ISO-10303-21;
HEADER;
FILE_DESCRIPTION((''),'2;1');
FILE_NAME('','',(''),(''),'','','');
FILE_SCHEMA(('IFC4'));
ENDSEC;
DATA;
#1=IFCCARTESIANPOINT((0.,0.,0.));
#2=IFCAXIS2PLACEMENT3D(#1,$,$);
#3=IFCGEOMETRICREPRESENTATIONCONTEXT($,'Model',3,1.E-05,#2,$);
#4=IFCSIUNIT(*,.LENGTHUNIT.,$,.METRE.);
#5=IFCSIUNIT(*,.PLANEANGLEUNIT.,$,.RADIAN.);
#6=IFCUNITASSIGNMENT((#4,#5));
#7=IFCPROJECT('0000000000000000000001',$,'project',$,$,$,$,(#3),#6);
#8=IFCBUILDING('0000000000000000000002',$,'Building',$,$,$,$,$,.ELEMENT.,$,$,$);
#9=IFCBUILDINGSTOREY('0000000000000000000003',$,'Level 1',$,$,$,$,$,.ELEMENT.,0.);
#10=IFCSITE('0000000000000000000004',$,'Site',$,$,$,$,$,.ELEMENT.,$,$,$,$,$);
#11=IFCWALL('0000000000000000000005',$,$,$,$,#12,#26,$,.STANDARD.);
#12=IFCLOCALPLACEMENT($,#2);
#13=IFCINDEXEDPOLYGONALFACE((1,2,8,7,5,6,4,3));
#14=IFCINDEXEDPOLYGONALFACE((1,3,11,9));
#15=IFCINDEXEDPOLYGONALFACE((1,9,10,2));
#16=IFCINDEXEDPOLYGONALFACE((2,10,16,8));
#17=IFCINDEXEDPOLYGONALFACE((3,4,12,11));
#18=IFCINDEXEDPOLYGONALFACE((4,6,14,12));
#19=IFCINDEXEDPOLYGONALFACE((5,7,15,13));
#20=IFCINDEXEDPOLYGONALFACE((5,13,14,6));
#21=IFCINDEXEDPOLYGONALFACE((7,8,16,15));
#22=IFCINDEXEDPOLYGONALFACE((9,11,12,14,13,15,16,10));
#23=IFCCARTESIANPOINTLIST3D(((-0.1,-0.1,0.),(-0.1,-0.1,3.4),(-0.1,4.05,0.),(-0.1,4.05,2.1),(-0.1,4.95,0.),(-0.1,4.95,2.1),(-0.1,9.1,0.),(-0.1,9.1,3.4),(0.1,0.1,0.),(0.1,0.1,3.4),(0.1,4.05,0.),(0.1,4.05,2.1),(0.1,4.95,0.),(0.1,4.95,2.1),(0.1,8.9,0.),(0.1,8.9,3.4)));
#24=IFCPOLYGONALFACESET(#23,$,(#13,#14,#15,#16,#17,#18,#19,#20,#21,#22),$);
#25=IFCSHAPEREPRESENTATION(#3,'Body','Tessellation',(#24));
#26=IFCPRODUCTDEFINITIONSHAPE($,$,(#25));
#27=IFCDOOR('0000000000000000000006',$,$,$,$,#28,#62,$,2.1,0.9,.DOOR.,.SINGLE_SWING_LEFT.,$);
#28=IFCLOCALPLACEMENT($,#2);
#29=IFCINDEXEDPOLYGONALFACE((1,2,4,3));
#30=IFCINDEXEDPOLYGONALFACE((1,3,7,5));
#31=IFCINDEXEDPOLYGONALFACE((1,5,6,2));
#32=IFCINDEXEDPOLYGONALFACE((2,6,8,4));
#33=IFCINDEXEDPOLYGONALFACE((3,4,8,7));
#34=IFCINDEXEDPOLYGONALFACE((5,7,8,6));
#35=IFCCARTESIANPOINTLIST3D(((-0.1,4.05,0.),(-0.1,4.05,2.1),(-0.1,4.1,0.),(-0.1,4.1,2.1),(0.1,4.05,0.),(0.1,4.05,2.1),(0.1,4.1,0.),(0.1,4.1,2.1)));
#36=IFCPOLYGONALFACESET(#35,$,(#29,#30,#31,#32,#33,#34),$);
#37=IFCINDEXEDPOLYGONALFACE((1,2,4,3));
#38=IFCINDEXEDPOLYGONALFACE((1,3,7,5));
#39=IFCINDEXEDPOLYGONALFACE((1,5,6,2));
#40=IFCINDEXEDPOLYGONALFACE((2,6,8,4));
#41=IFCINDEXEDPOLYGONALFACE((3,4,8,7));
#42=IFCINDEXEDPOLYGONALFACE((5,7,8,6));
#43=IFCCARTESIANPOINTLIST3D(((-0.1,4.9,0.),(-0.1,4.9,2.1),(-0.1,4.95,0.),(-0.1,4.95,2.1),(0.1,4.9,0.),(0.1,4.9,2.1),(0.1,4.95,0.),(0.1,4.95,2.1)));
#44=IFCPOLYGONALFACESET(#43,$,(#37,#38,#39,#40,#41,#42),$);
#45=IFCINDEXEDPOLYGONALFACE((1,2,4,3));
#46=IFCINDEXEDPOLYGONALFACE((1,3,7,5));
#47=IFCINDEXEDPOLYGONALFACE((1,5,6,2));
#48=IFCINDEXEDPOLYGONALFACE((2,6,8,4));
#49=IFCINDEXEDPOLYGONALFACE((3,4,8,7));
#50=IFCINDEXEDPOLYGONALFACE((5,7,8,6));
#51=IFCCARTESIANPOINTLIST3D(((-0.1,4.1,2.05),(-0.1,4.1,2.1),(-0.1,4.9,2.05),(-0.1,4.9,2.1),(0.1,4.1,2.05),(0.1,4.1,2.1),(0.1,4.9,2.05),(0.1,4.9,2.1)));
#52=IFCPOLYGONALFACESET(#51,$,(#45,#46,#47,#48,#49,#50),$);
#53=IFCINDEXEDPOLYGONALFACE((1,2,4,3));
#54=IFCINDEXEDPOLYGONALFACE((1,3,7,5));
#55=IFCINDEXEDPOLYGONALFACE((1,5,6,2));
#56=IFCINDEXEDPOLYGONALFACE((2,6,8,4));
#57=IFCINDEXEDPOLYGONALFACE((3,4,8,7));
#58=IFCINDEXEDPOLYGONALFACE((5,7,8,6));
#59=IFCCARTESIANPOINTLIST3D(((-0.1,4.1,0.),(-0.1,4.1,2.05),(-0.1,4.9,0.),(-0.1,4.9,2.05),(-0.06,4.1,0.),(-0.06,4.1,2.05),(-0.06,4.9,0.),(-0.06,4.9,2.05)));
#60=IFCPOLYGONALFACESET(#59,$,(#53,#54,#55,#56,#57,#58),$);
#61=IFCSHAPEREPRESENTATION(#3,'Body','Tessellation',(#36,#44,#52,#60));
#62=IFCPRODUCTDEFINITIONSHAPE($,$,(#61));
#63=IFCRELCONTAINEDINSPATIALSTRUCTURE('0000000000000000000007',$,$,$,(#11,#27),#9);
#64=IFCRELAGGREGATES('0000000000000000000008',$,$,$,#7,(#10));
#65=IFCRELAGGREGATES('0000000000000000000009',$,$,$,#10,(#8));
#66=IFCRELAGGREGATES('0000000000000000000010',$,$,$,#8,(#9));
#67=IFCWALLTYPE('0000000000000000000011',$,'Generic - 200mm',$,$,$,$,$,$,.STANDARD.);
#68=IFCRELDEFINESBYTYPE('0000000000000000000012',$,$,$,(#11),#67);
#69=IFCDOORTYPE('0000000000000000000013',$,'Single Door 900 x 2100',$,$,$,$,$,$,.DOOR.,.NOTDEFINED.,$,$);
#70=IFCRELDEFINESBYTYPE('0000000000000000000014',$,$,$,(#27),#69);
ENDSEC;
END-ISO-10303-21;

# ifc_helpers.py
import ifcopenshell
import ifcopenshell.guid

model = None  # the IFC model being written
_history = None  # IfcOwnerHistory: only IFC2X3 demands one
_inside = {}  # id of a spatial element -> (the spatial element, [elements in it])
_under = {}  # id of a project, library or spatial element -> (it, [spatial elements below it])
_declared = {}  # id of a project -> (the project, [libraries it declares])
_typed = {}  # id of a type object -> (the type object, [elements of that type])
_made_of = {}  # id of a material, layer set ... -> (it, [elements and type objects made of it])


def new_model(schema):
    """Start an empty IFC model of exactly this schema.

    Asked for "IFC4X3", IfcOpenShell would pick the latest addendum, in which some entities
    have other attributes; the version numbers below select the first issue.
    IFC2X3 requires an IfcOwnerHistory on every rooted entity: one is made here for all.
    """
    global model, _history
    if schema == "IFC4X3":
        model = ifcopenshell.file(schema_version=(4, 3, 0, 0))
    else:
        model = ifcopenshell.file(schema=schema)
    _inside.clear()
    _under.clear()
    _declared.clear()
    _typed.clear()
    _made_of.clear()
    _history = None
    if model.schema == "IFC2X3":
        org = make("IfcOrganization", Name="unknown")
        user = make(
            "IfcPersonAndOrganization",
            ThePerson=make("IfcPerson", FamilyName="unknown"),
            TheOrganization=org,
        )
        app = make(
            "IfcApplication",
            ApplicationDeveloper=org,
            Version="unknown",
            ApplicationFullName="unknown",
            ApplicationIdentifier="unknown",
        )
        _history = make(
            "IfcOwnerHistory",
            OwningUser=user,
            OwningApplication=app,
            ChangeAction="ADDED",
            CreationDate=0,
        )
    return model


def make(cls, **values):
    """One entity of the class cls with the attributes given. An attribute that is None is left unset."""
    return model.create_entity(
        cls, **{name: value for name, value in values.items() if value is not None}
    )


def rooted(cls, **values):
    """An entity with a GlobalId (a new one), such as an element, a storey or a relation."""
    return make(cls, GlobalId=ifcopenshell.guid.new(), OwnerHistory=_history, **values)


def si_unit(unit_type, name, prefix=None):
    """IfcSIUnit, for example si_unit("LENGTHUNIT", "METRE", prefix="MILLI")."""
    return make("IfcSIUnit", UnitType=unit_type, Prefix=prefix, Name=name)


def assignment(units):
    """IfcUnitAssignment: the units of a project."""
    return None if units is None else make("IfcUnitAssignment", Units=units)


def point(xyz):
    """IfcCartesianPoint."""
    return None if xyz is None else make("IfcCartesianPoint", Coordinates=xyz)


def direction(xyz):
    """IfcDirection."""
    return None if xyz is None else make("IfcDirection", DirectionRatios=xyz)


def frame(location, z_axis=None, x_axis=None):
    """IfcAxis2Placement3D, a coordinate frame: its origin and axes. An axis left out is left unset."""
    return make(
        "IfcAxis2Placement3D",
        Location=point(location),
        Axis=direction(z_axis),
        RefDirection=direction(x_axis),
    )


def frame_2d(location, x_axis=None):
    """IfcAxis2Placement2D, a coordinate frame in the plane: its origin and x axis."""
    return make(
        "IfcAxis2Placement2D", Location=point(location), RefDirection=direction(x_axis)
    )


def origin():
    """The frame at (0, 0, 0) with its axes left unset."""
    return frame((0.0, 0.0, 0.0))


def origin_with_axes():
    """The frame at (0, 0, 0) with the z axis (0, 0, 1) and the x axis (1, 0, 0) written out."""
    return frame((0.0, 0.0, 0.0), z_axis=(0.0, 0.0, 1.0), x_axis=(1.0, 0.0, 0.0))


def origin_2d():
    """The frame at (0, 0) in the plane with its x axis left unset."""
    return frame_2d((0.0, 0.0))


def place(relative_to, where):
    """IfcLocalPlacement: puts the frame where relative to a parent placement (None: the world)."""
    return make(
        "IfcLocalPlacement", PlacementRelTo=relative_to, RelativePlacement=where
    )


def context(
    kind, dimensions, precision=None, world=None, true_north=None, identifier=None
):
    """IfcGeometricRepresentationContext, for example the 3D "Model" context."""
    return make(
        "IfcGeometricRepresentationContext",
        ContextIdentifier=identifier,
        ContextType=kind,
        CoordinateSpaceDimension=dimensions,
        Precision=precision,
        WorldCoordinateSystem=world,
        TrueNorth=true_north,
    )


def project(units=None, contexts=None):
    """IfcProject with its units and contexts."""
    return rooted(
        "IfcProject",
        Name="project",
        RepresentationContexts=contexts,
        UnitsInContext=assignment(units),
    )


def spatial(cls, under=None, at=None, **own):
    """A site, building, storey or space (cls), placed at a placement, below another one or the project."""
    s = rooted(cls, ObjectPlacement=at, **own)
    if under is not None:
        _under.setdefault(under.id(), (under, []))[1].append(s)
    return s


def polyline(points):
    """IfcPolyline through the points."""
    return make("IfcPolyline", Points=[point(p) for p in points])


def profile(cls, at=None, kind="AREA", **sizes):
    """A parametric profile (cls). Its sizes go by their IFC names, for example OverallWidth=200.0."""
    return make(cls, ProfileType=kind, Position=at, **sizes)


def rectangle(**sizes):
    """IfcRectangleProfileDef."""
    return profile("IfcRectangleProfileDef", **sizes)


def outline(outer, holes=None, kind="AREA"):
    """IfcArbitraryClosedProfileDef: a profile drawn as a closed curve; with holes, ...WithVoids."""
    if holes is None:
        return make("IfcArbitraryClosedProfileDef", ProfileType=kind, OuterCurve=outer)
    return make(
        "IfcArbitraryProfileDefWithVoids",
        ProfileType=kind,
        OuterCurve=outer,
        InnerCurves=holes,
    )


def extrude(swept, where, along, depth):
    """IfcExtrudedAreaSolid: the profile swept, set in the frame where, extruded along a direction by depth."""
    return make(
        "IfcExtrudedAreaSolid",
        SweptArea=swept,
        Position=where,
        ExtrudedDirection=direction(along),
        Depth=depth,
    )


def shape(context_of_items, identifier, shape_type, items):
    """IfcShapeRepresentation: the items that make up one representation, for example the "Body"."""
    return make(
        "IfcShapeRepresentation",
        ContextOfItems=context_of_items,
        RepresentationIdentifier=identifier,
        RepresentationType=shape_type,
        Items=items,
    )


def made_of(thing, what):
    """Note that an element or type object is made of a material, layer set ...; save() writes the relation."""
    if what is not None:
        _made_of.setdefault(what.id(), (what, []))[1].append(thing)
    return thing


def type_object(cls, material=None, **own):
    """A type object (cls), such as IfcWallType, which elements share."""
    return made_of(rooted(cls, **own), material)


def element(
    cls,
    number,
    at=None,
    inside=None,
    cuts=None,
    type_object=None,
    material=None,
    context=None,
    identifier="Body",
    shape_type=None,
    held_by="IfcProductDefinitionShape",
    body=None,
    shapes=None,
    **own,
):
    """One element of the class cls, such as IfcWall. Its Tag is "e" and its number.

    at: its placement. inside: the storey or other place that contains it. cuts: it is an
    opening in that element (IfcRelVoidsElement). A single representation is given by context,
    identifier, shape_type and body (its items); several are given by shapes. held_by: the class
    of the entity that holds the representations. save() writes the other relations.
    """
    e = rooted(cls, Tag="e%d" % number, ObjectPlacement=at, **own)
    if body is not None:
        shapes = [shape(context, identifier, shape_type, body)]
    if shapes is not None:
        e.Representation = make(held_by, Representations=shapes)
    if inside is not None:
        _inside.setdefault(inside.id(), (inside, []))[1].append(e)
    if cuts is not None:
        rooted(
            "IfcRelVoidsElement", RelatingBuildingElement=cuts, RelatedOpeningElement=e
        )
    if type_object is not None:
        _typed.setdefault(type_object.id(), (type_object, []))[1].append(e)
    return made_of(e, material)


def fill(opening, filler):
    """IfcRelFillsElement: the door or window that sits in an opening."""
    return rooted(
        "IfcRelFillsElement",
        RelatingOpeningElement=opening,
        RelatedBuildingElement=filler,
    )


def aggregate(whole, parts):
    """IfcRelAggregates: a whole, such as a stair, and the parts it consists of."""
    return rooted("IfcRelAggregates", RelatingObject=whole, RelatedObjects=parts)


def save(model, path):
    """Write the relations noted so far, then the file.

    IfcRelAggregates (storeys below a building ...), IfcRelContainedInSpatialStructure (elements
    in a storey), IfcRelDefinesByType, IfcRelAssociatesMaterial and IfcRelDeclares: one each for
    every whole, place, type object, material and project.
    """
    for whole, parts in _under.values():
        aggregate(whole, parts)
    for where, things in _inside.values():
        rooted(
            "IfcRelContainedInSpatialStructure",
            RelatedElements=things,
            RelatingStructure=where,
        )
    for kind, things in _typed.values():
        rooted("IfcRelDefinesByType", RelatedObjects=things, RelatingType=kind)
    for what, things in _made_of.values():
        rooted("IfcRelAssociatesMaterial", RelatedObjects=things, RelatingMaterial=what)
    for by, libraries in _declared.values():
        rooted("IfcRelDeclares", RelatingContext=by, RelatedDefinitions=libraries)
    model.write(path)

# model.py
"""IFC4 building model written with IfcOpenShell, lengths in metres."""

from ifc_helpers import new_model, si_unit, frame, frame_2d, origin, origin_with_axes, origin_2d, place, context, project, spatial, polyline, rectangle, outline, extrude, type_object, element, fill, save


model = new_model("IFC4")

# Units and contexts
model_context = context("Model", 3, precision=1e-05, world=origin())
ifc_project = project(units=[si_unit("LENGTHUNIT", "METRE"), si_unit("PLANEANGLEUNIT", "RADIAN")], contexts=[model_context])

# Site, building, storey
site = spatial("IfcSite", under=ifc_project, Name="Site", CompositionType="ELEMENT")
building = spatial("IfcBuilding", under=site, Name="Building", CompositionType="ELEMENT")
storey = spatial("IfcBuildingStorey", under=building, Name="Level 1", CompositionType="ELEMENT", Elevation=0.0)

# Shared definitions
wall_type = type_object("IfcWallType", Name="Generic - 200mm", PredefinedType="STANDARD")

# Wall, opening, door
wall_1_placement = place(None, frame((0.0, 0.0, 0.0), z_axis=(0.0, 0.0, 1.0), x_axis=(0.0, 1.0, 0.0)))
wall_1 = element("IfcWall", 1, at=wall_1_placement, inside=storey, type_object=wall_type, PredefinedType="STANDARD", context=model_context, shape_type="SweptSolid", body=[
    extrude(outline(polyline([(0.1, -0.1), (8.9, -0.1), (9.1, 0.1), (-0.1, 0.1), (0.1, -0.1)])), origin(), (0.0, 0.0, 1.0), 3.4),
])
opening_1_placement = place(wall_1_placement, frame((4.5, 0.0, 0.0), z_axis=(0.0, 0.0, 1.0), x_axis=(1.0, 0.0, 0.0)))
opening_1 = element("IfcOpeningElement", 2, at=opening_1_placement, cuts=wall_1, PredefinedType="OPENING", context=model_context, shape_type="SweptSolid", body=[
    extrude(rectangle(XDim=0.9, YDim=0.202, at=origin_2d()), origin(), (0.0, 0.0, 1.0), 2.1),
])
door_type = type_object("IfcDoorType", Name="Single Door 900 x 2100", OperationType="NOTDEFINED", PredefinedType="DOOR")
door_placement = place(opening_1_placement, origin_with_axes())
door = element("IfcDoor", 3, at=door_placement, inside=storey, type_object=door_type, OperationType="SINGLE_SWING_LEFT", OverallHeight=2.1, OverallWidth=0.9, PredefinedType="DOOR", context=model_context, shape_type="SweptSolid", body=[
    extrude(rectangle(XDim=0.05, YDim=0.2, at=frame_2d((-0.425, 0.0))), origin(), (0.0, 0.0, 1.0), 2.1),
    extrude(rectangle(XDim=0.05, YDim=0.2, at=frame_2d((0.425, 0.0))), origin(), (0.0, 0.0, 1.0), 2.1),
    extrude(rectangle(XDim=0.8, YDim=0.2, at=origin_2d()), frame((0.0, 0.0, 2.05)), (0.0, 0.0, 1.0), 0.05),
    extrude(rectangle(XDim=0.8, YDim=0.04, at=frame_2d((0.0, 0.08))), origin(), (0.0, 0.0, 1.0), 2.05),
])
fill(opening_1, door)

save(model, "model.ifc")
